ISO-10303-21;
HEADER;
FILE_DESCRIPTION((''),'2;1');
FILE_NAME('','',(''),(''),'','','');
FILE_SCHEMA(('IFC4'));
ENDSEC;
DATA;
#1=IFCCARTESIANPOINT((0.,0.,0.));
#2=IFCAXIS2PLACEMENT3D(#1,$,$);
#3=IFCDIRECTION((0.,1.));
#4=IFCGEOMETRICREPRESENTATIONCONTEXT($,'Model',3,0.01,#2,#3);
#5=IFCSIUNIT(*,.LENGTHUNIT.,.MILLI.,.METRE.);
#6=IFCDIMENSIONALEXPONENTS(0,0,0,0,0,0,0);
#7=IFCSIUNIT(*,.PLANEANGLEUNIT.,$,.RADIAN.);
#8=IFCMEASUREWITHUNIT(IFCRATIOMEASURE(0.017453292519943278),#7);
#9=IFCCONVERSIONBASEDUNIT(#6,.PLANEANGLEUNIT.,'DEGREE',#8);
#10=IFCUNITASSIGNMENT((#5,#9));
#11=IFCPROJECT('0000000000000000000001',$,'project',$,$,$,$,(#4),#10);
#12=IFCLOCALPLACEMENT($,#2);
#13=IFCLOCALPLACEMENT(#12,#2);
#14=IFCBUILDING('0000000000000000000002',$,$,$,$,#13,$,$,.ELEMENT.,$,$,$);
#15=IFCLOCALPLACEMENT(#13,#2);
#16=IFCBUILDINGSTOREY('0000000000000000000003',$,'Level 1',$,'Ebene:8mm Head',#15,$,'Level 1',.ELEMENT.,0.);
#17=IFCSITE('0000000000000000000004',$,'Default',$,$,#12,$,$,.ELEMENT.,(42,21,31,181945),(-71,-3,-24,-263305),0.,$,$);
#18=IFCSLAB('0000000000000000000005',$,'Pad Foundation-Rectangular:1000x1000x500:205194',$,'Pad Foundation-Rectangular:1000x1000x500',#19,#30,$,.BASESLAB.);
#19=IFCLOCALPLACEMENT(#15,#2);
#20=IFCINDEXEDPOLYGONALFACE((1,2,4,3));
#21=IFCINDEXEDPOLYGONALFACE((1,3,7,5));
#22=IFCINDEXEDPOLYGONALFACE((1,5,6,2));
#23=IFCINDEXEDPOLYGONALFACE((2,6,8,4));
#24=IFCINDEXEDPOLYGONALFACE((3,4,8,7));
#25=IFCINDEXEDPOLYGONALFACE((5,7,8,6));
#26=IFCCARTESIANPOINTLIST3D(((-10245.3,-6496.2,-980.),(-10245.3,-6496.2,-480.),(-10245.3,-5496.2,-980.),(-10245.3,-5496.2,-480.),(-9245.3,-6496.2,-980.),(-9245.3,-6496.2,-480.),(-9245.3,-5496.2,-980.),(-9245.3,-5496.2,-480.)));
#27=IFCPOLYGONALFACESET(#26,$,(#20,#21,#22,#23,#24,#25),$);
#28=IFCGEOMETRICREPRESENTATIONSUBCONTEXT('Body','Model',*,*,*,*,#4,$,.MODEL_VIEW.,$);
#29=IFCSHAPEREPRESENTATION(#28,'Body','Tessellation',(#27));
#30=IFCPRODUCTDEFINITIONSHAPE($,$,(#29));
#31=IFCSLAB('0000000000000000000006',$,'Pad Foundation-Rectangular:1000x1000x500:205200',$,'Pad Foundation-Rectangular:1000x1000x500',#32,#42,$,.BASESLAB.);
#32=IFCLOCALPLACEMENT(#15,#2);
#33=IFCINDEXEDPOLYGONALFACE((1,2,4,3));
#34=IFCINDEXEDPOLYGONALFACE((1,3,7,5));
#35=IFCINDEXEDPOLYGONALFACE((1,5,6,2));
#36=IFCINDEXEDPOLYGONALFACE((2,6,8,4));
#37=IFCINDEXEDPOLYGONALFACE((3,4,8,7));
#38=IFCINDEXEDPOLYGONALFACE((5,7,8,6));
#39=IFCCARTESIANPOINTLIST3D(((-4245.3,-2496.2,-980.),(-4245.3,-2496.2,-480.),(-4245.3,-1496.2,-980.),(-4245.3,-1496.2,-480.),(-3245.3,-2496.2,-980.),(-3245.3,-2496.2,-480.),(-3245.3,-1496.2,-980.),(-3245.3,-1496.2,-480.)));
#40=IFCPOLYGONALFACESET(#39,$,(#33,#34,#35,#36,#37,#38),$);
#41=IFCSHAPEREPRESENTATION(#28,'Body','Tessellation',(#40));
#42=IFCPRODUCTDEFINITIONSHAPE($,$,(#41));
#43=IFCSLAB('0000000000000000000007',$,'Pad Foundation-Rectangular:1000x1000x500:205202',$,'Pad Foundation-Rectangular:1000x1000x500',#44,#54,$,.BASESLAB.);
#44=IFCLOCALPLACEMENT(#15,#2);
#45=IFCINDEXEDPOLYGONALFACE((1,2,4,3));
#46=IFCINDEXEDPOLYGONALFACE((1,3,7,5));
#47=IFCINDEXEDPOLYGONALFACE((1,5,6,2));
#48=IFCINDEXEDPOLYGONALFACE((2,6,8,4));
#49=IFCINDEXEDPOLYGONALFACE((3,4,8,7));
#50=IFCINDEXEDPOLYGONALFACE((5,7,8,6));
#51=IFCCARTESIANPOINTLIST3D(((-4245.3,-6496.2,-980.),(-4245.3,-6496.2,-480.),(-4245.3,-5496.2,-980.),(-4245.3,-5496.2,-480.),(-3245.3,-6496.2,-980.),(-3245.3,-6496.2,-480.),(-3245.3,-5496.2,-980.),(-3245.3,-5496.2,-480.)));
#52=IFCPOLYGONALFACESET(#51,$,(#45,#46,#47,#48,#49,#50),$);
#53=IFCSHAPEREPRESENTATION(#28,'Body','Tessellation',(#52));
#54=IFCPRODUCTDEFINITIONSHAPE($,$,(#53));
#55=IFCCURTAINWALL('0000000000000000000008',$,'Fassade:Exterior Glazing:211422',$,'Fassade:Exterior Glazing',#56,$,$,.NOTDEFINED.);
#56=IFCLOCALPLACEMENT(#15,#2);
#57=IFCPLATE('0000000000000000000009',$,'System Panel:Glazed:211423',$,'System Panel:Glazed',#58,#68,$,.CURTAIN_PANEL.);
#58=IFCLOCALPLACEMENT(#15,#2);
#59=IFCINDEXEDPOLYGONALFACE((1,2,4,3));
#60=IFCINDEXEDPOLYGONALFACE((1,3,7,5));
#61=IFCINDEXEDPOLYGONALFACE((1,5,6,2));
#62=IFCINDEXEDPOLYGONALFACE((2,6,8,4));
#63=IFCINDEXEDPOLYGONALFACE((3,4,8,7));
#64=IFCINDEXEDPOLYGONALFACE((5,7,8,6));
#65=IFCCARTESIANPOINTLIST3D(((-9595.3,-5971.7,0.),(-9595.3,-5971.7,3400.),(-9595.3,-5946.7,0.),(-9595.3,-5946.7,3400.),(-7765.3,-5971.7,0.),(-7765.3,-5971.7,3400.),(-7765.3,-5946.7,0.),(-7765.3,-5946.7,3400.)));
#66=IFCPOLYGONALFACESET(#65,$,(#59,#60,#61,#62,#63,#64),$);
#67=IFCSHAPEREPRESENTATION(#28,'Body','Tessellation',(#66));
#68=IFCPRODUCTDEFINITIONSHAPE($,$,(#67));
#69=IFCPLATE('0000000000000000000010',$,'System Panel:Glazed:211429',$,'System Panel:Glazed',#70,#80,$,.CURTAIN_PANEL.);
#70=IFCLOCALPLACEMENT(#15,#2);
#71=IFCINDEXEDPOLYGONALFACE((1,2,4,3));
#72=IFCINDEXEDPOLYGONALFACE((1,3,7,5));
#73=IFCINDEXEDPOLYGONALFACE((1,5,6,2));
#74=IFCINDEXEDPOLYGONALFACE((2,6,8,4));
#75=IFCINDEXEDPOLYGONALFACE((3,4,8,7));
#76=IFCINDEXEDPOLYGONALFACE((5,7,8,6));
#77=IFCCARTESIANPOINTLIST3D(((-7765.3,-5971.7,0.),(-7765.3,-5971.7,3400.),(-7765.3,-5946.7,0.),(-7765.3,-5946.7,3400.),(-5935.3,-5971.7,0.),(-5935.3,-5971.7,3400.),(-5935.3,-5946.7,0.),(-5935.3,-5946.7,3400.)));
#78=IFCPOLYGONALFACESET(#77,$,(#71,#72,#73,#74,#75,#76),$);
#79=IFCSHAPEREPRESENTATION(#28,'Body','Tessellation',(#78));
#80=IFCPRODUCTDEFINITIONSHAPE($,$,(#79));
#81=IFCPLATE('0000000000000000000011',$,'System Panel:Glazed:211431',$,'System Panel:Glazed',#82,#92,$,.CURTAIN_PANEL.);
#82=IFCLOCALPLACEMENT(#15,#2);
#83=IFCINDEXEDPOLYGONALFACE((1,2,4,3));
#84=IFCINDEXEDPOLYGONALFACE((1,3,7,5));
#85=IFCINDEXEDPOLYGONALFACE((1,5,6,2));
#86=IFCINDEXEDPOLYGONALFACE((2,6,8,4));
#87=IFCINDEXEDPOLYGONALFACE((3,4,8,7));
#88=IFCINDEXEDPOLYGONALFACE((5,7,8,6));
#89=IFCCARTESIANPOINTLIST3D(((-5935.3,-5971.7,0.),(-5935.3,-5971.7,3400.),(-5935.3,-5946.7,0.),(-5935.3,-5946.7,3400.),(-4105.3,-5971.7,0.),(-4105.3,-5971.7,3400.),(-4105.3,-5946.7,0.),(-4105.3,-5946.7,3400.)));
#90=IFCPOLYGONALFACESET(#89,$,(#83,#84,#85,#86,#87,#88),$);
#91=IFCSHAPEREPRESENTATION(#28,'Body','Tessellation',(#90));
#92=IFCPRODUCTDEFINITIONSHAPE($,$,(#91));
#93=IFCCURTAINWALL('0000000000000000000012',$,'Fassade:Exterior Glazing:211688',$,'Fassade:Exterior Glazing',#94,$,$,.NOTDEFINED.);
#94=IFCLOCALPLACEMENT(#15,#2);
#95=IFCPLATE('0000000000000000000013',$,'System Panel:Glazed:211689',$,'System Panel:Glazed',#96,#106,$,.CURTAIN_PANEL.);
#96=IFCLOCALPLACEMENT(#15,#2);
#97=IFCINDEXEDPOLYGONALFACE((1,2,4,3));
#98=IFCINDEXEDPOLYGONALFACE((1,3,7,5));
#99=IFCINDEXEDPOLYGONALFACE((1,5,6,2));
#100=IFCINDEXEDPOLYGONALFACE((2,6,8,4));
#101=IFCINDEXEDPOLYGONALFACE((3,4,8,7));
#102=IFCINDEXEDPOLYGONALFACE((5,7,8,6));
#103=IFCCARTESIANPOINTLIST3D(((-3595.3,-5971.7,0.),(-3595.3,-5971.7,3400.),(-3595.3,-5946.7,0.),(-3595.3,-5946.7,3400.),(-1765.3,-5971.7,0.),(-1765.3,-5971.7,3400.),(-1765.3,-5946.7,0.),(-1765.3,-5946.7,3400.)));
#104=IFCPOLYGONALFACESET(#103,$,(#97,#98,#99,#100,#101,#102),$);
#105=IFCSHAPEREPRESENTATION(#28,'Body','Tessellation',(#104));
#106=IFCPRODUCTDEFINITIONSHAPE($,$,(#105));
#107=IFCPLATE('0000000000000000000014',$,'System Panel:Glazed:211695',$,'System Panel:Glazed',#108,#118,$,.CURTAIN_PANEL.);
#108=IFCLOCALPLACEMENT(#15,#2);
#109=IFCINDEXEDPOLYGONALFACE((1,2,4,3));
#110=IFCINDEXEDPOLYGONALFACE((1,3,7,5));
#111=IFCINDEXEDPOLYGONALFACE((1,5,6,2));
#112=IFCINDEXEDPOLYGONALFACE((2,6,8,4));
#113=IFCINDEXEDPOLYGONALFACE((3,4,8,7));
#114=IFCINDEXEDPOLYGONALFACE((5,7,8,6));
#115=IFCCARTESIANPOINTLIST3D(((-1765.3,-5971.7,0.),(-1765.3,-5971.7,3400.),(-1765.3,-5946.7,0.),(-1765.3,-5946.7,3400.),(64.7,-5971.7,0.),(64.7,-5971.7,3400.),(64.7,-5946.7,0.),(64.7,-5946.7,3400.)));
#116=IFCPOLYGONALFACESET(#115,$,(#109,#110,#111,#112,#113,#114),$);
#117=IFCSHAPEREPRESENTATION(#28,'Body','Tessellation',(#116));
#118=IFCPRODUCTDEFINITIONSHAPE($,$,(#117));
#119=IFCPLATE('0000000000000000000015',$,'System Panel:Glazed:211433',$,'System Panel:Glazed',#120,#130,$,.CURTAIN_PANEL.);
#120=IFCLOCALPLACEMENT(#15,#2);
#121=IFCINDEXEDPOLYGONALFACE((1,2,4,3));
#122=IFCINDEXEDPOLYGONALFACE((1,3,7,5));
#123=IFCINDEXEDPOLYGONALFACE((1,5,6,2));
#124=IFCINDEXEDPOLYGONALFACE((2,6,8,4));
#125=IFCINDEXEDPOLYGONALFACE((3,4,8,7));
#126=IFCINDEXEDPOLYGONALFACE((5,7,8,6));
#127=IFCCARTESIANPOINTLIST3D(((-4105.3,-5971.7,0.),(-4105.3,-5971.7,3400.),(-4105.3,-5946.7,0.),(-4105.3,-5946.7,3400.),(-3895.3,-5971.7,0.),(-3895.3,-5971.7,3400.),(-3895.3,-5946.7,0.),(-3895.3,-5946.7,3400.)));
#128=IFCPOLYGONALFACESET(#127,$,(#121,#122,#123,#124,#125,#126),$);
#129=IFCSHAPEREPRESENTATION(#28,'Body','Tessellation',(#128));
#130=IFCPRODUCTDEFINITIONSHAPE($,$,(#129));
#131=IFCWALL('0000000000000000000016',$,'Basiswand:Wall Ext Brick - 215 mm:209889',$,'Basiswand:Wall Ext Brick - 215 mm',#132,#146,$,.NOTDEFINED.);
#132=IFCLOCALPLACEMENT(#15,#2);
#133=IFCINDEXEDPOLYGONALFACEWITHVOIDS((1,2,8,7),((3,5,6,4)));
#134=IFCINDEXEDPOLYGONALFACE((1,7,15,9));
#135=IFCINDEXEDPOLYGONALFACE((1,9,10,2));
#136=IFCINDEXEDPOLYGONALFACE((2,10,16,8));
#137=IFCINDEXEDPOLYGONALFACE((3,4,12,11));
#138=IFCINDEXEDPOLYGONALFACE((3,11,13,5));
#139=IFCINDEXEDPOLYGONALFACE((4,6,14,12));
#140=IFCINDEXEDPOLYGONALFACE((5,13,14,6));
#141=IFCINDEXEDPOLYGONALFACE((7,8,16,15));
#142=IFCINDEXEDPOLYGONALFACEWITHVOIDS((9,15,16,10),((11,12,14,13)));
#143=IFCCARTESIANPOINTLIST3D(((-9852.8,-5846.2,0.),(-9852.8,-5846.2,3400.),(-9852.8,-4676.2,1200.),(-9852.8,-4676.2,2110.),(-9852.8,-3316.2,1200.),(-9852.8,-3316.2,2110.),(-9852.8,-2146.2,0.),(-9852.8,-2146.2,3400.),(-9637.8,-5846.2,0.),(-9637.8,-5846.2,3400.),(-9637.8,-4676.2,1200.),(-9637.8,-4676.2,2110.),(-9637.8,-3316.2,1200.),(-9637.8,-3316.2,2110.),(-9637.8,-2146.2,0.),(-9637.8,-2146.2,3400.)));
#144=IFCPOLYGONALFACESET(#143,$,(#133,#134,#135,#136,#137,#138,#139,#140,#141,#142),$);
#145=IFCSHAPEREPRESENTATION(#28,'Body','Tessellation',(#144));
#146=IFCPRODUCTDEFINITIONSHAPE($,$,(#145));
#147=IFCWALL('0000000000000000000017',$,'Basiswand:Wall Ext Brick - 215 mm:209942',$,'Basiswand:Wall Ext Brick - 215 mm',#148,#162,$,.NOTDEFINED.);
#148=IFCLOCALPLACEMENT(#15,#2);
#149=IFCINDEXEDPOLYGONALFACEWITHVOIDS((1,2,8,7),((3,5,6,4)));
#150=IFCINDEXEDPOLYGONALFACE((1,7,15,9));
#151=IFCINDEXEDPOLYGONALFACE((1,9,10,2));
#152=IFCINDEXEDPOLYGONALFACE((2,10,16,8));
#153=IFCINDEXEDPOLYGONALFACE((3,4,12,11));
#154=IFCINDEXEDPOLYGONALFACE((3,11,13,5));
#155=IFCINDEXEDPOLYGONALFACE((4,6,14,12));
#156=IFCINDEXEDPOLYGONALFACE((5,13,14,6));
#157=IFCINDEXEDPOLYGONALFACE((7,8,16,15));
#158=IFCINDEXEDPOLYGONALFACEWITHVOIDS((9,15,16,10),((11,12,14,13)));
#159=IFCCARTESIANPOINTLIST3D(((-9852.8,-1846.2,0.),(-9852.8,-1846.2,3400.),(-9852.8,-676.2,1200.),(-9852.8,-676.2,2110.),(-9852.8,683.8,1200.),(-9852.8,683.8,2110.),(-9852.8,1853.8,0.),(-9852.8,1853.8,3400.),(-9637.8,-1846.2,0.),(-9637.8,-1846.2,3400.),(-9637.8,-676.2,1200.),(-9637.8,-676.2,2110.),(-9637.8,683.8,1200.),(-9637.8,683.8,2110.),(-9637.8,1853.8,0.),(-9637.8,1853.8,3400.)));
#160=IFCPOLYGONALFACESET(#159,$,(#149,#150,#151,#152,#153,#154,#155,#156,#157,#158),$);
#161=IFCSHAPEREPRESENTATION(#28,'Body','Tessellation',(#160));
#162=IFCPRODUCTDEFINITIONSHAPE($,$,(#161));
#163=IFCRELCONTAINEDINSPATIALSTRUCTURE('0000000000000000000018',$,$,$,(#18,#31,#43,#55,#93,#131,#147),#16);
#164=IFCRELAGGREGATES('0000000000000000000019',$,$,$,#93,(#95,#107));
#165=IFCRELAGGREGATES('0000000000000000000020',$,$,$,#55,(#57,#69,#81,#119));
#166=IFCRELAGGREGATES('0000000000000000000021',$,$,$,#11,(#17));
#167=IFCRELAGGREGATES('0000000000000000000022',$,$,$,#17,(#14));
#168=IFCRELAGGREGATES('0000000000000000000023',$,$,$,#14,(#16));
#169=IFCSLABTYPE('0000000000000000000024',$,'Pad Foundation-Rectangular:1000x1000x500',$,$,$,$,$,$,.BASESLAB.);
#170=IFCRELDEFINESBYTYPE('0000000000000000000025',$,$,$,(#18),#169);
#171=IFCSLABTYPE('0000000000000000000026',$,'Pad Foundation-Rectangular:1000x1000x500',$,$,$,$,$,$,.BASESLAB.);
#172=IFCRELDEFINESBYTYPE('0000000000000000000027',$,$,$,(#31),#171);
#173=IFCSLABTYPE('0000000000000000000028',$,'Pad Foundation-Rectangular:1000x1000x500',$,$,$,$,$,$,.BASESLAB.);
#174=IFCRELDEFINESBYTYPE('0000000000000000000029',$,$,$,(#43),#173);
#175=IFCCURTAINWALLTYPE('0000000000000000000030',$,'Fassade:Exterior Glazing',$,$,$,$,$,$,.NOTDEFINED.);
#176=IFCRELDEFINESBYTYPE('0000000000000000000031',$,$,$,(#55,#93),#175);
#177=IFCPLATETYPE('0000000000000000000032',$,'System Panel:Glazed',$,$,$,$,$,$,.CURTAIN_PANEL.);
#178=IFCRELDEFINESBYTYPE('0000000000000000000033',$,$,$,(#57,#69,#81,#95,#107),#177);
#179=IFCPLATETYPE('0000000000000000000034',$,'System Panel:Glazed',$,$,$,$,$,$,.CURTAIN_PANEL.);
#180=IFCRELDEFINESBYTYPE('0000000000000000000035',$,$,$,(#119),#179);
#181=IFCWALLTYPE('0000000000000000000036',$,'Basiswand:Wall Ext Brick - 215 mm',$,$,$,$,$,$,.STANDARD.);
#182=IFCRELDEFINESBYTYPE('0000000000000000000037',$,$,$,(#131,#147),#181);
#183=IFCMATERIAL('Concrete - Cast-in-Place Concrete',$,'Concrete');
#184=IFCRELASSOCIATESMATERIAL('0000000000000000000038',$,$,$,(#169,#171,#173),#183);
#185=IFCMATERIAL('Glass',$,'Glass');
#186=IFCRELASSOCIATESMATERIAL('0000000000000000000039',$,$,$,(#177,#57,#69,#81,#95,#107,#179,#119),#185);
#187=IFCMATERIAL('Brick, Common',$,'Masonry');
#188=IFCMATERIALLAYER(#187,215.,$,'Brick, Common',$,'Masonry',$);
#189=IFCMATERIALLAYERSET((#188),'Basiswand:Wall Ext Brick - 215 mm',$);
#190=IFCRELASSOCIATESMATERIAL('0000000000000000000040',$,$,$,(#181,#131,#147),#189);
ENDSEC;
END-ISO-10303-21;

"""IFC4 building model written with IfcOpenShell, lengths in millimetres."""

from ifc_helpers import new_model, entity, si_unit, converted_unit, direction, frame, frame_2d, origin, origin_2d_with_axis, place, context, subcontext, project, spatial, rectangle, extrude, source, transform, mapped, material, layer, layer_set, layer_usage, type_object, type_shapes, element, aggregate, save


model = new_model("IFC4")

# Units and contexts
model_context = context("Model", 3, precision=0.01, world=origin(), true_north=direction((0.0, 1.0)))
body_context = subcontext(model_context, "Body", "Model", "MODEL_VIEW")
ifc_project = project(units=[si_unit("LENGTHUNIT", "METRE", prefix="MILLI"), converted_unit("PLANEANGLEUNIT", "DEGREE", entity("IfcRatioMeasure", 0.017453292519943278), si_unit("PLANEANGLEUNIT", "RADIAN"), dimensions=[0, 0, 0, 0, 0, 0, 0])], contexts=[model_context])

# Site, building, storey
site_placement = place(None, origin())
site = spatial("IfcSite", under=ifc_project, at=site_placement, Name="Default", CompositionType="ELEMENT", RefLatitude=(42, 21, 31, 181945), RefLongitude=(-71, -3, -24, -263305), RefElevation=0.0)
building_placement = place(site_placement, origin())
building = spatial("IfcBuilding", under=site, at=building_placement, CompositionType="ELEMENT")
storey_placement = place(building_placement, origin())
storey = spatial("IfcBuildingStorey", under=building, at=storey_placement, Name="Level 1", ObjectType="Ebene:8mm Head", LongName="Level 1", CompositionType="ELEMENT", Elevation=0.0)

# Shared definitions
ifc_material_1 = material(Name="Concrete - Cast-in-Place Concrete", Category="Concrete")

# Slabs
slab_type_1 = type_object("IfcSlabType", Name="Pad Foundation-Rectangular:1000x1000x500", PredefinedType="BASESLAB", material=ifc_material_1)
slab_1_placement = place(storey_placement, frame((-10245.3, -6496.2, -980.0)))
element("IfcSlab", 1, at=slab_1_placement, inside=storey, type_object=slab_type_1, Name="Pad Foundation-Rectangular:1000x1000x500:205194", ObjectType="Pad Foundation-Rectangular:1000x1000x500", PredefinedType="BASESLAB", context=body_context, shape_type="SweptSolid", body=[
    extrude(rectangle(XDim=1000.0, YDim=1000.0, at=frame_2d((0.0, 0.0), x_axis=(1.0, 0.0))), frame((500.0, 500.0, 0.0), z_axis=(0.0, 0.0, 1.0), x_axis=(-1.0, 0.0, 0.0)), (0.0, 0.0, 1.0), 500.0),
])
slab_type_2 = type_object("IfcSlabType", Name="Pad Foundation-Rectangular:1000x1000x500", PredefinedType="BASESLAB", material=ifc_material_1)
slab_2_placement = place(storey_placement, frame((-4245.3, -2496.2, -980.0)))
element("IfcSlab", 2, at=slab_2_placement, inside=storey, type_object=slab_type_2, Name="Pad Foundation-Rectangular:1000x1000x500:205200", ObjectType="Pad Foundation-Rectangular:1000x1000x500", PredefinedType="BASESLAB", context=body_context, shape_type="SweptSolid", body=[
    extrude(rectangle(XDim=1000.0, YDim=1000.0, at=origin_2d_with_axis()), frame((500.0, 500.0, 0.0), z_axis=(0.0, 0.0, 1.0), x_axis=(-1.0, 0.0, 0.0)), (0.0, 0.0, 1.0), 500.0),
])
slab_type_3 = type_object("IfcSlabType", Name="Pad Foundation-Rectangular:1000x1000x500", PredefinedType="BASESLAB", material=ifc_material_1)
slab_3_placement = place(storey_placement, frame((-4245.3, -6496.2, -980.0)))
element("IfcSlab", 3, at=slab_3_placement, inside=storey, type_object=slab_type_3, Name="Pad Foundation-Rectangular:1000x1000x500:205202", ObjectType="Pad Foundation-Rectangular:1000x1000x500", PredefinedType="BASESLAB", context=body_context, shape_type="SweptSolid", body=[
    extrude(rectangle(XDim=1000.0, YDim=1000.0, at=frame_2d((0.0, 0.0), x_axis=(1.0, 0.0))), frame((500.0, 500.0, 0.0), z_axis=(0.0, 0.0, 1.0), x_axis=(-1.0, 0.0, 0.0)), (0.0, 0.0, 1.0), 500.0),
])

# Curtain walls, plates
curtain_wall_type = type_object("IfcCurtainWallType", Name="Fassade:Exterior Glazing", PredefinedType="NOTDEFINED")
curtain_wall_1_placement = place(storey_placement, origin())
curtain_wall_1 = element("IfcCurtainWall", 4, at=curtain_wall_1_placement, inside=storey, type_object=curtain_wall_type, Name="Fassade:Exterior Glazing:211422", ObjectType="Fassade:Exterior Glazing", PredefinedType="NOTDEFINED")
ifc_material_2 = material(Name="Glass", Category="Glass")
plate_type_1 = type_object("IfcPlateType", Name="System Panel:Glazed", PredefinedType="CURTAIN_PANEL", material=ifc_material_2)
shared_shape_1 = source(origin(), body_context, "Body", "SweptSolid", [
    extrude(rectangle(XDim=25.0, YDim=1830.0, at=origin_2d_with_axis()), frame((915.0, 12.5, 0.0), z_axis=(0.0, 0.0, 1.0), x_axis=(0.0, 1.0, 0.0)), (0.0, 0.0, 1.0), 3400.0),
])
type_shapes(plate_type_1, [shared_shape_1])
plate_1_placement = place(curtain_wall_1_placement, frame((-9595.3, -5971.7, 0.0)))
plate_1 = element("IfcPlate", 5, at=plate_1_placement, type_object=plate_type_1, material=ifc_material_2, Name="System Panel:Glazed:211423", ObjectType="System Panel:Glazed", PredefinedType="CURTAIN_PANEL", context=body_context, shape_type="MappedRepresentation", body=[
    mapped(shared_shape_1, transform((0.0, 0.0, 0.0), scale=1.0)),
])
plate_2_placement = place(curtain_wall_1_placement, frame((-7765.3, -5971.7, 0.0)))
plate_2 = element("IfcPlate", 6, at=plate_2_placement, type_object=plate_type_1, material=ifc_material_2, Name="System Panel:Glazed:211429", ObjectType="System Panel:Glazed", PredefinedType="CURTAIN_PANEL", context=body_context, shape_type="MappedRepresentation", body=[
    mapped(shared_shape_1, transform((0.0, 0.0, 0.0), scale=1.0)),
])
plate_3_placement = place(curtain_wall_1_placement, frame((-5935.3, -5971.7, 0.0)))
plate_3 = element("IfcPlate", 7, at=plate_3_placement, type_object=plate_type_1, material=ifc_material_2, Name="System Panel:Glazed:211431", ObjectType="System Panel:Glazed", PredefinedType="CURTAIN_PANEL", context=body_context, shape_type="MappedRepresentation", body=[
    mapped(shared_shape_1, transform((0.0, 0.0, 0.0), scale=1.0)),
])
curtain_wall_2_placement = place(storey_placement, origin())
curtain_wall_2 = element("IfcCurtainWall", 8, at=curtain_wall_2_placement, inside=storey, type_object=curtain_wall_type, Name="Fassade:Exterior Glazing:211688", ObjectType="Fassade:Exterior Glazing", PredefinedType="NOTDEFINED")
plate_4_placement = place(curtain_wall_2_placement, frame((-3595.3, -5971.7, 0.0)))
plate_4 = element("IfcPlate", 9, at=plate_4_placement, type_object=plate_type_1, material=ifc_material_2, Name="System Panel:Glazed:211689", ObjectType="System Panel:Glazed", PredefinedType="CURTAIN_PANEL", context=body_context, shape_type="MappedRepresentation", body=[
    mapped(shared_shape_1, transform((0.0, 0.0, 0.0), scale=1.0)),
])
plate_5_placement = place(curtain_wall_2_placement, frame((-1765.3, -5971.7, 0.0)))
plate_5 = element("IfcPlate", 10, at=plate_5_placement, type_object=plate_type_1, material=ifc_material_2, Name="System Panel:Glazed:211695", ObjectType="System Panel:Glazed", PredefinedType="CURTAIN_PANEL", context=body_context, shape_type="MappedRepresentation", body=[
    mapped(shared_shape_1, transform((0.0, 0.0, 0.0), scale=1.0)),
])
aggregate(curtain_wall_2, [plate_4, plate_5])

# Plate
plate_type_2 = type_object("IfcPlateType", Name="System Panel:Glazed", PredefinedType="CURTAIN_PANEL", material=ifc_material_2)
shared_shape_2 = source(origin(), body_context, "Body", "SweptSolid", [
    extrude(rectangle(XDim=25.0, YDim=210.0, at=origin_2d_with_axis()), frame((105.0, 12.5, 0.0), z_axis=(0.0, 0.0, 1.0), x_axis=(0.0, 1.0, 0.0)), (0.0, 0.0, 1.0), 3400.0),
])
type_shapes(plate_type_2, [shared_shape_2])
plate_6_placement = place(curtain_wall_1_placement, frame((-4105.3, -5971.7, 0.0)))
plate_6 = element("IfcPlate", 11, at=plate_6_placement, type_object=plate_type_2, material=ifc_material_2, Name="System Panel:Glazed:211433", ObjectType="System Panel:Glazed", PredefinedType="CURTAIN_PANEL", context=body_context, shape_type="MappedRepresentation", body=[
    mapped(shared_shape_2, transform((0.0, 0.0, 0.0), scale=1.0)),
])
aggregate(curtain_wall_1, [plate_1, plate_2, plate_3, plate_6])

# Walls, openings
ifc_material_3 = material(Name="Brick, Common", Category="Masonry")
ifc_layer = layer(ifc_material_3, 215.0, Name="Brick, Common", Category="Masonry")
ifc_layer_set = layer_set([ifc_layer], Name="Basiswand:Wall Ext Brick - 215 mm")
ifc_layer_usage_1 = layer_usage(ifc_layer_set, "AXIS2", "NEGATIVE", 107.5)
wall_type = type_object("IfcWallType", Name="Basiswand:Wall Ext Brick - 215 mm", PredefinedType="STANDARD", material=ifc_layer_set)
wall_1_placement = place(storey_placement, frame((-9745.3, -5846.2, 0.0), z_axis=(0.0, 0.0, 1.0), x_axis=(0.0, 1.0, 0.0)))
wall_1 = element("IfcWall", 12, at=wall_1_placement, inside=storey, type_object=wall_type, material=ifc_layer_usage_1, Name="Basiswand:Wall Ext Brick - 215 mm:209889", ObjectType="Basiswand:Wall Ext Brick - 215 mm", PredefinedType="NOTDEFINED", context=body_context, shape_type="SweptSolid", body=[
    extrude(rectangle(XDim=3700.0, YDim=215.0, at=frame_2d((1850.0, 0.0), x_axis=(-1.0, 0.0))), origin(), (0.0, 0.0, 1.0), 3400.0),
])
opening_1_placement = place(wall_1_placement, frame((2530.0, 107.5, 1200.0)))
element("IfcOpeningElement", 13, at=opening_1_placement, cuts=wall_1, PredefinedType="OPENING", context=body_context, shape_type="SweptSolid", body=[
    extrude(rectangle(XDim=910.0, YDim=1360.0, at=frame_2d((455.0, 680.0), x_axis=(-1.0, 0.0))), frame((0.0, 0.0, 0.0), z_axis=(0.0, -1.0, 0.0), x_axis=(0.0, 0.0, 1.0)), (0.0, 0.0, 1.0), 215.0),
])
ifc_layer_usage_2 = layer_usage(ifc_layer_set, "AXIS2", "NEGATIVE", 107.5)
wall_2_placement = place(storey_placement, frame((-9745.3, -1846.2, 0.0), z_axis=(0.0, 0.0, 1.0), x_axis=(0.0, 1.0, 0.0)))
wall_2 = element("IfcWall", 14, at=wall_2_placement, inside=storey, type_object=wall_type, material=ifc_layer_usage_2, Name="Basiswand:Wall Ext Brick - 215 mm:209942", ObjectType="Basiswand:Wall Ext Brick - 215 mm", PredefinedType="NOTDEFINED", context=body_context, shape_type="SweptSolid", body=[
    extrude(rectangle(XDim=3700.0, YDim=215.0, at=frame_2d((1850.0, 0.0), x_axis=(-1.0, 0.0))), origin(), (0.0, 0.0, 1.0), 3400.0),
])
opening_2_placement = place(wall_2_placement, frame((2530.0, 107.5, 1200.0)))
element("IfcOpeningElement", 15, at=opening_2_placement, cuts=wall_2, PredefinedType="OPENING", context=body_context, shape_type="SweptSolid", body=[
    extrude(rectangle(XDim=910.0, YDim=1360.0, at=frame_2d((455.0, 680.0), x_axis=(-1.0, 0.0))), frame((0.0, 0.0, 0.0), z_axis=(0.0, -1.0, 0.0), x_axis=(0.0, 0.0, 1.0)), (0.0, 0.0, 1.0), 215.0),
])

save(model, "model.ifc")
